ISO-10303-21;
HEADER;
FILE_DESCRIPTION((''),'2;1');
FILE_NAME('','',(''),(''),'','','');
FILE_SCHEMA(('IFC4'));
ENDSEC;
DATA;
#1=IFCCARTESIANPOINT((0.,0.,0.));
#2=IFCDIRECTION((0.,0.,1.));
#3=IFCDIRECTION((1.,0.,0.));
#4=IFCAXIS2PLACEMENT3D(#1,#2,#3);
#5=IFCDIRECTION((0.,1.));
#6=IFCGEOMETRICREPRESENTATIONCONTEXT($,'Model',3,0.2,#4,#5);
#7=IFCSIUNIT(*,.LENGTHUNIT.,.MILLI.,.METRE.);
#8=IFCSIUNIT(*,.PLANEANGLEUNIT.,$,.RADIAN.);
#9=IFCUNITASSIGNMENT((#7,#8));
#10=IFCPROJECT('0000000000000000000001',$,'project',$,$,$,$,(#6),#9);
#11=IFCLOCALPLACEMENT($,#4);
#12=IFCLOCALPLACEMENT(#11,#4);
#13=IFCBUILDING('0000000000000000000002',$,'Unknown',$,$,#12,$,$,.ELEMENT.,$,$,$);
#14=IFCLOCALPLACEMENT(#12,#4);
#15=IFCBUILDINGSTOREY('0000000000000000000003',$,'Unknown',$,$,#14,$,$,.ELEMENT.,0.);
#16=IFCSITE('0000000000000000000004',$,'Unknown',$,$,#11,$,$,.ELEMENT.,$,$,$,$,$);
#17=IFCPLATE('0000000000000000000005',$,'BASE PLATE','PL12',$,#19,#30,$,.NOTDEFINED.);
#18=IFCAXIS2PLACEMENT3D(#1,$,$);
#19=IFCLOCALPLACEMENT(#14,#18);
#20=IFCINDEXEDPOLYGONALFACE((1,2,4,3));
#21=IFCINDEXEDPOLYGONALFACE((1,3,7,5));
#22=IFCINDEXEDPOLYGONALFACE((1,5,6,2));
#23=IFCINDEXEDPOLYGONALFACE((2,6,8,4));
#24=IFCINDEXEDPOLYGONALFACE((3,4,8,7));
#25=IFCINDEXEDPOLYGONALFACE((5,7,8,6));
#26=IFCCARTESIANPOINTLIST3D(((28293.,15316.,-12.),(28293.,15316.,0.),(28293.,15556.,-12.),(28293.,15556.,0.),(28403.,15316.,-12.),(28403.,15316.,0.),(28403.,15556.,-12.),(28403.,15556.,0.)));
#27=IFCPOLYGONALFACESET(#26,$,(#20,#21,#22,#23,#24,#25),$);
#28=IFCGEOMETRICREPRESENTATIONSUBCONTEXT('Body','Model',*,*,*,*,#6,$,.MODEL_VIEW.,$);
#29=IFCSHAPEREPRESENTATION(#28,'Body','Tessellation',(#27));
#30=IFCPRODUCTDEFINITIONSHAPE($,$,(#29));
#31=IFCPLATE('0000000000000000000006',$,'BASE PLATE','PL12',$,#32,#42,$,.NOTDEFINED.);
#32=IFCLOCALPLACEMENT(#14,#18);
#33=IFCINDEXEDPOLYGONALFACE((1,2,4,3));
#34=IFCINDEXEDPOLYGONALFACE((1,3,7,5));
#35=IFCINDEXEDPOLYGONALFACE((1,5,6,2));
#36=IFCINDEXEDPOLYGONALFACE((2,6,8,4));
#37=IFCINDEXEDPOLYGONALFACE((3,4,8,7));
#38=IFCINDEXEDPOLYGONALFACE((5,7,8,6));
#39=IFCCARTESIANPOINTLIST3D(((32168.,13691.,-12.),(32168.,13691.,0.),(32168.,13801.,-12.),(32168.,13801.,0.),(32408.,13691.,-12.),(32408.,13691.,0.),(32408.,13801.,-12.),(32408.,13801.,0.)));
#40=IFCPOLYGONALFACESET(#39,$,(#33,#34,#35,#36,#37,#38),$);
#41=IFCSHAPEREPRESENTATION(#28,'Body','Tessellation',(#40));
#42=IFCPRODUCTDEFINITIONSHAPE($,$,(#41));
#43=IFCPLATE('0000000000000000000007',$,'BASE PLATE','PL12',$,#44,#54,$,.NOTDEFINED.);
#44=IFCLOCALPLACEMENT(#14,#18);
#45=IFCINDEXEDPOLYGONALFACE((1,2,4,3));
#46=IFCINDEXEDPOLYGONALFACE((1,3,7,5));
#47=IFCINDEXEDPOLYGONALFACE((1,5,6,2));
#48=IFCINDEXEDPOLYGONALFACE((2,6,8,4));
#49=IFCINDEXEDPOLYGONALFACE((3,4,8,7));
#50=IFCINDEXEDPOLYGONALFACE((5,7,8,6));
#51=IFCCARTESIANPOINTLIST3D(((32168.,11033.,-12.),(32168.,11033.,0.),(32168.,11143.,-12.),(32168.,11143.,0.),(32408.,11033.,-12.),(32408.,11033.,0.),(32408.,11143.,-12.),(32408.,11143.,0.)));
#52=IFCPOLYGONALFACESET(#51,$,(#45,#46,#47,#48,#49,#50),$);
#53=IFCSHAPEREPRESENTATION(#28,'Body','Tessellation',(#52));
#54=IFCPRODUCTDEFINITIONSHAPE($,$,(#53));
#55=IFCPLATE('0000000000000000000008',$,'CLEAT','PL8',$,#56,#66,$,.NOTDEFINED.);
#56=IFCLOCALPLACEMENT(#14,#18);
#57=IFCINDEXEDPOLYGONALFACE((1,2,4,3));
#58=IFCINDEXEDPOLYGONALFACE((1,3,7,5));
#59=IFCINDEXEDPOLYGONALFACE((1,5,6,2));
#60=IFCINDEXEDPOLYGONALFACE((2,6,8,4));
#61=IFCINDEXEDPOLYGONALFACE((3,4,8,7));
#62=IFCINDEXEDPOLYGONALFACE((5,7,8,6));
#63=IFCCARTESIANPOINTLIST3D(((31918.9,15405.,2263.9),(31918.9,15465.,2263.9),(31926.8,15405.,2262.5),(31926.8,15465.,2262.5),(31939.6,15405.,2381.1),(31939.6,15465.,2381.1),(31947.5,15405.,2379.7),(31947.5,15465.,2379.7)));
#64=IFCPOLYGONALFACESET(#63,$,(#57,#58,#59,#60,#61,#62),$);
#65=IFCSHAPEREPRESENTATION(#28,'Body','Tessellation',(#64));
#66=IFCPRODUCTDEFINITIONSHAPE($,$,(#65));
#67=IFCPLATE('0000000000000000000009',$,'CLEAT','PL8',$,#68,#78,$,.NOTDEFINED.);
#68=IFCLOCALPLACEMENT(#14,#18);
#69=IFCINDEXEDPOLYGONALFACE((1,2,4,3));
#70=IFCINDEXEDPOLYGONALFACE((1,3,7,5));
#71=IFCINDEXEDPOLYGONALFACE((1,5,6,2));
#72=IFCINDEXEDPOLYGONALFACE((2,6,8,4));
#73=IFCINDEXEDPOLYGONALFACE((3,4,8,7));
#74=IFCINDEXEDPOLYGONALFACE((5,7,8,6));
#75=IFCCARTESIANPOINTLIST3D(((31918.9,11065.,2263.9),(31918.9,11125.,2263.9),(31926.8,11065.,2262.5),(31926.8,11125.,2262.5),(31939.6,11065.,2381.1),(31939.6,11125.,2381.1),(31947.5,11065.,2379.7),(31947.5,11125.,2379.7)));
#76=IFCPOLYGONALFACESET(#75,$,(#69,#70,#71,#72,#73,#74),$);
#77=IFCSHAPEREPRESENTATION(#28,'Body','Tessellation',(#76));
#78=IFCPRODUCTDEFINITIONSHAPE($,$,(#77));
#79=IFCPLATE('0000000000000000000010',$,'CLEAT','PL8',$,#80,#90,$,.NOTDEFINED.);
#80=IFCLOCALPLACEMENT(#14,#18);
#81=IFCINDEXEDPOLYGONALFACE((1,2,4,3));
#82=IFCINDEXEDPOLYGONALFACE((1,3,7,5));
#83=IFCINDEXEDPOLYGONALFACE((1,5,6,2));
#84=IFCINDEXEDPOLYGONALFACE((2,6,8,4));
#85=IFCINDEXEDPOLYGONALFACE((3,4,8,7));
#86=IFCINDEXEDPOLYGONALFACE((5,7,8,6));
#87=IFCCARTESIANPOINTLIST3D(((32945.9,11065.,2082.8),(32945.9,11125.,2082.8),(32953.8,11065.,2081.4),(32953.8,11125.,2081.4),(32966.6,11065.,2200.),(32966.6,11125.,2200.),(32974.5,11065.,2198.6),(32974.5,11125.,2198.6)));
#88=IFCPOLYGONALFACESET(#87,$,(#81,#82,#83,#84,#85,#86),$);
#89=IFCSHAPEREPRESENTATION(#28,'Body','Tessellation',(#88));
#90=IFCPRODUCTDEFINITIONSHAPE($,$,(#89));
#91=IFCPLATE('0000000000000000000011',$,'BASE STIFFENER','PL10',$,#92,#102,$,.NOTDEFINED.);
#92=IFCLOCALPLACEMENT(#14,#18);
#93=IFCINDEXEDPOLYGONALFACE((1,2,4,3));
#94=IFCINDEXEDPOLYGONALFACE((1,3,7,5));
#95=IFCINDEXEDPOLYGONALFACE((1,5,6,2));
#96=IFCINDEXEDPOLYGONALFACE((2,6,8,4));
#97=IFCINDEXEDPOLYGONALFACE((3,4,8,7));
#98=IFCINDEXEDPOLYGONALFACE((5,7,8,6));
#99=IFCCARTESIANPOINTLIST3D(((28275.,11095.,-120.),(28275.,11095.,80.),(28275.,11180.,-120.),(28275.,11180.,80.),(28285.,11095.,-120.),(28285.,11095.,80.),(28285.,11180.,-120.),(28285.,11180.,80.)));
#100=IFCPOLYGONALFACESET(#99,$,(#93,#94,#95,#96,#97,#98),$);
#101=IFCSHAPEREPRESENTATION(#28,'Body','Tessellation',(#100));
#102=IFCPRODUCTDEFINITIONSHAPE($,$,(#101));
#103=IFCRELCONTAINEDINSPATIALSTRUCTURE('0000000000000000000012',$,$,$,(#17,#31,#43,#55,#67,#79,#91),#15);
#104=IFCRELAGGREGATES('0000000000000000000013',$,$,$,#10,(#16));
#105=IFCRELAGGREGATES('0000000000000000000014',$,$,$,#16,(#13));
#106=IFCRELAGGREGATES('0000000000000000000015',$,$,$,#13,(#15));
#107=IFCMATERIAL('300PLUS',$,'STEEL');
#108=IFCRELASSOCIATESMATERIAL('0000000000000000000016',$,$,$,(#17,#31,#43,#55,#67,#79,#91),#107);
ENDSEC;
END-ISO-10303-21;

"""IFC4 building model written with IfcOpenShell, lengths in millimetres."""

from ifc_helpers import new_model, si_unit, direction, frame, origin_with_axes, place, context, subcontext, project, spatial, line, indexed_curve, outline, extrude, material, element, save


model = new_model("IFC4")

# Units and contexts
model_context = context("Model", 3, precision=0.2, world=origin_with_axes(), true_north=direction((0.0, 1.0)))
body_context = subcontext(model_context, "Body", "Model", "MODEL_VIEW")
ifc_project = project(units=[si_unit("LENGTHUNIT", "METRE", prefix="MILLI"), si_unit("PLANEANGLEUNIT", "RADIAN")], contexts=[model_context])

# Site, building, storey
site_placement = place(None, origin_with_axes())
site = spatial("IfcSite", under=ifc_project, at=site_placement, Name="Unknown", CompositionType="ELEMENT")
building_placement = place(site_placement, origin_with_axes())
building = spatial("IfcBuilding", under=site, at=building_placement, Name="Unknown", CompositionType="ELEMENT")
storey_placement = place(building_placement, origin_with_axes())
storey = spatial("IfcBuildingStorey", under=building, at=storey_placement, Name="Unknown", CompositionType="ELEMENT", Elevation=0.0)

# Plates
ifc_material_1 = material(Name="300PLUS", Category="STEEL")
plate_1_placement = place(storey_placement, frame((28293.0, 15316.0, -6.0), z_axis=(0.0, 0.0, 1.0), x_axis=(1.0, 0.0, 0.0)))
element("IfcPlate", 1, at=plate_1_placement, inside=storey, material=ifc_material_1, Name="BASE PLATE", Description="PL12", PredefinedType="NOTDEFINED", context=body_context, shape_type="SolidModel", body=[
    extrude(outline(indexed_curve([(0.0, 0.0), (110.0, 0.0), (110.0, 240.0), (0.0, 240.0)], segments=[line(1, 2, 3, 4, 1)])), frame((0.0, 0.0, 6.0), z_axis=(0.0, 0.0, 1.0), x_axis=(1.0, 0.0, 0.0)), (0.0, 0.0, -1.0), 12.0),
])
for number, where, z_axis, x_axis, name in (
    (2, (32168.0, 13691.0, -6.0), (0.0, 0.0, 1.0), (1.0, 0.0, 0.0), "BASE PLATE"),
    (3, (32168.0, 11033.0, -6.0), (0.0, 0.0, 1.0), (1.0, 0.0, 0.0), "BASE PLATE"),
):
    element("IfcPlate", number, at=place(storey_placement, frame(where, z_axis=z_axis, x_axis=x_axis)), inside=storey, material=ifc_material_1, Name=name, Description="PL12", PredefinedType="NOTDEFINED", context=body_context, shape_type="SolidModel", body=[
        extrude(outline(indexed_curve([(0.0, 0.0), (240.0, 0.0), (240.0, 110.0), (0.0, 110.0)], segments=[line(1, 2, 3, 4, 1)])), frame((0.0, 0.0, 6.0), z_axis=(0.0, 0.0, 1.0), x_axis=(1.0, 0.0, 0.0)), (0.0, 0.0, -1.0), 12.0),
    ])
for number, where, z_axis, x_axis, name in (
    (4, (31922.9, 15465.0, 2263.2), (-0.984758, 0.0, 0.173929), (0.0, -1.0, 0.0), "CLEAT"),
    (5, (31922.9, 11125.0, 2263.2), (-0.984758, 0.0, 0.173929), (0.0, -1.0, 0.0), "CLEAT"),
    (6, (32949.9, 11125.0, 2082.1), (-0.984758, 0.0, 0.173929), (0.0, -1.0, 0.0), "CLEAT"),
):
    element("IfcPlate", number, at=place(storey_placement, frame(where, z_axis=z_axis, x_axis=x_axis)), inside=storey, material=ifc_material_1, Name=name, Description="PL8", PredefinedType="NOTDEFINED", context=body_context, shape_type="SolidModel", body=[
        extrude(outline(indexed_curve([(0.0, 0.0), (60.0, 0.0), (60.0, 119.0), (0.0, 119.0)], segments=[line(1, 2, 3, 4, 1)])), frame((0.0, 0.0, 4.0), z_axis=(0.0, 0.0, 1.0), x_axis=(1.0, 0.0, 0.0)), (0.0, 0.0, -1.0), 8.0),
    ])
plate_2_placement = place(storey_placement, frame((28280.0, 11095.0, -120.0), z_axis=(1.0, 0.0, 0.0), x_axis=(0.0, 1.0, 0.0)))
element("IfcPlate", 7, at=plate_2_placement, inside=storey, material=ifc_material_1, Name="BASE STIFFENER", Description="PL10", PredefinedType="NOTDEFINED", context=body_context, shape_type="SolidModel", body=[
    extrude(outline(indexed_curve([(0.0, 0.0), (85.0, 0.0), (85.0, 200.0), (0.0, 200.0)], segments=[line(1, 2, 3, 4, 1)])), frame((0.0, 0.0, 5.0), z_axis=(0.0, 0.0, 1.0), x_axis=(1.0, 0.0, 0.0)), (0.0, 0.0, -1.0), 10.0),
])

save(model, "model.ifc")
